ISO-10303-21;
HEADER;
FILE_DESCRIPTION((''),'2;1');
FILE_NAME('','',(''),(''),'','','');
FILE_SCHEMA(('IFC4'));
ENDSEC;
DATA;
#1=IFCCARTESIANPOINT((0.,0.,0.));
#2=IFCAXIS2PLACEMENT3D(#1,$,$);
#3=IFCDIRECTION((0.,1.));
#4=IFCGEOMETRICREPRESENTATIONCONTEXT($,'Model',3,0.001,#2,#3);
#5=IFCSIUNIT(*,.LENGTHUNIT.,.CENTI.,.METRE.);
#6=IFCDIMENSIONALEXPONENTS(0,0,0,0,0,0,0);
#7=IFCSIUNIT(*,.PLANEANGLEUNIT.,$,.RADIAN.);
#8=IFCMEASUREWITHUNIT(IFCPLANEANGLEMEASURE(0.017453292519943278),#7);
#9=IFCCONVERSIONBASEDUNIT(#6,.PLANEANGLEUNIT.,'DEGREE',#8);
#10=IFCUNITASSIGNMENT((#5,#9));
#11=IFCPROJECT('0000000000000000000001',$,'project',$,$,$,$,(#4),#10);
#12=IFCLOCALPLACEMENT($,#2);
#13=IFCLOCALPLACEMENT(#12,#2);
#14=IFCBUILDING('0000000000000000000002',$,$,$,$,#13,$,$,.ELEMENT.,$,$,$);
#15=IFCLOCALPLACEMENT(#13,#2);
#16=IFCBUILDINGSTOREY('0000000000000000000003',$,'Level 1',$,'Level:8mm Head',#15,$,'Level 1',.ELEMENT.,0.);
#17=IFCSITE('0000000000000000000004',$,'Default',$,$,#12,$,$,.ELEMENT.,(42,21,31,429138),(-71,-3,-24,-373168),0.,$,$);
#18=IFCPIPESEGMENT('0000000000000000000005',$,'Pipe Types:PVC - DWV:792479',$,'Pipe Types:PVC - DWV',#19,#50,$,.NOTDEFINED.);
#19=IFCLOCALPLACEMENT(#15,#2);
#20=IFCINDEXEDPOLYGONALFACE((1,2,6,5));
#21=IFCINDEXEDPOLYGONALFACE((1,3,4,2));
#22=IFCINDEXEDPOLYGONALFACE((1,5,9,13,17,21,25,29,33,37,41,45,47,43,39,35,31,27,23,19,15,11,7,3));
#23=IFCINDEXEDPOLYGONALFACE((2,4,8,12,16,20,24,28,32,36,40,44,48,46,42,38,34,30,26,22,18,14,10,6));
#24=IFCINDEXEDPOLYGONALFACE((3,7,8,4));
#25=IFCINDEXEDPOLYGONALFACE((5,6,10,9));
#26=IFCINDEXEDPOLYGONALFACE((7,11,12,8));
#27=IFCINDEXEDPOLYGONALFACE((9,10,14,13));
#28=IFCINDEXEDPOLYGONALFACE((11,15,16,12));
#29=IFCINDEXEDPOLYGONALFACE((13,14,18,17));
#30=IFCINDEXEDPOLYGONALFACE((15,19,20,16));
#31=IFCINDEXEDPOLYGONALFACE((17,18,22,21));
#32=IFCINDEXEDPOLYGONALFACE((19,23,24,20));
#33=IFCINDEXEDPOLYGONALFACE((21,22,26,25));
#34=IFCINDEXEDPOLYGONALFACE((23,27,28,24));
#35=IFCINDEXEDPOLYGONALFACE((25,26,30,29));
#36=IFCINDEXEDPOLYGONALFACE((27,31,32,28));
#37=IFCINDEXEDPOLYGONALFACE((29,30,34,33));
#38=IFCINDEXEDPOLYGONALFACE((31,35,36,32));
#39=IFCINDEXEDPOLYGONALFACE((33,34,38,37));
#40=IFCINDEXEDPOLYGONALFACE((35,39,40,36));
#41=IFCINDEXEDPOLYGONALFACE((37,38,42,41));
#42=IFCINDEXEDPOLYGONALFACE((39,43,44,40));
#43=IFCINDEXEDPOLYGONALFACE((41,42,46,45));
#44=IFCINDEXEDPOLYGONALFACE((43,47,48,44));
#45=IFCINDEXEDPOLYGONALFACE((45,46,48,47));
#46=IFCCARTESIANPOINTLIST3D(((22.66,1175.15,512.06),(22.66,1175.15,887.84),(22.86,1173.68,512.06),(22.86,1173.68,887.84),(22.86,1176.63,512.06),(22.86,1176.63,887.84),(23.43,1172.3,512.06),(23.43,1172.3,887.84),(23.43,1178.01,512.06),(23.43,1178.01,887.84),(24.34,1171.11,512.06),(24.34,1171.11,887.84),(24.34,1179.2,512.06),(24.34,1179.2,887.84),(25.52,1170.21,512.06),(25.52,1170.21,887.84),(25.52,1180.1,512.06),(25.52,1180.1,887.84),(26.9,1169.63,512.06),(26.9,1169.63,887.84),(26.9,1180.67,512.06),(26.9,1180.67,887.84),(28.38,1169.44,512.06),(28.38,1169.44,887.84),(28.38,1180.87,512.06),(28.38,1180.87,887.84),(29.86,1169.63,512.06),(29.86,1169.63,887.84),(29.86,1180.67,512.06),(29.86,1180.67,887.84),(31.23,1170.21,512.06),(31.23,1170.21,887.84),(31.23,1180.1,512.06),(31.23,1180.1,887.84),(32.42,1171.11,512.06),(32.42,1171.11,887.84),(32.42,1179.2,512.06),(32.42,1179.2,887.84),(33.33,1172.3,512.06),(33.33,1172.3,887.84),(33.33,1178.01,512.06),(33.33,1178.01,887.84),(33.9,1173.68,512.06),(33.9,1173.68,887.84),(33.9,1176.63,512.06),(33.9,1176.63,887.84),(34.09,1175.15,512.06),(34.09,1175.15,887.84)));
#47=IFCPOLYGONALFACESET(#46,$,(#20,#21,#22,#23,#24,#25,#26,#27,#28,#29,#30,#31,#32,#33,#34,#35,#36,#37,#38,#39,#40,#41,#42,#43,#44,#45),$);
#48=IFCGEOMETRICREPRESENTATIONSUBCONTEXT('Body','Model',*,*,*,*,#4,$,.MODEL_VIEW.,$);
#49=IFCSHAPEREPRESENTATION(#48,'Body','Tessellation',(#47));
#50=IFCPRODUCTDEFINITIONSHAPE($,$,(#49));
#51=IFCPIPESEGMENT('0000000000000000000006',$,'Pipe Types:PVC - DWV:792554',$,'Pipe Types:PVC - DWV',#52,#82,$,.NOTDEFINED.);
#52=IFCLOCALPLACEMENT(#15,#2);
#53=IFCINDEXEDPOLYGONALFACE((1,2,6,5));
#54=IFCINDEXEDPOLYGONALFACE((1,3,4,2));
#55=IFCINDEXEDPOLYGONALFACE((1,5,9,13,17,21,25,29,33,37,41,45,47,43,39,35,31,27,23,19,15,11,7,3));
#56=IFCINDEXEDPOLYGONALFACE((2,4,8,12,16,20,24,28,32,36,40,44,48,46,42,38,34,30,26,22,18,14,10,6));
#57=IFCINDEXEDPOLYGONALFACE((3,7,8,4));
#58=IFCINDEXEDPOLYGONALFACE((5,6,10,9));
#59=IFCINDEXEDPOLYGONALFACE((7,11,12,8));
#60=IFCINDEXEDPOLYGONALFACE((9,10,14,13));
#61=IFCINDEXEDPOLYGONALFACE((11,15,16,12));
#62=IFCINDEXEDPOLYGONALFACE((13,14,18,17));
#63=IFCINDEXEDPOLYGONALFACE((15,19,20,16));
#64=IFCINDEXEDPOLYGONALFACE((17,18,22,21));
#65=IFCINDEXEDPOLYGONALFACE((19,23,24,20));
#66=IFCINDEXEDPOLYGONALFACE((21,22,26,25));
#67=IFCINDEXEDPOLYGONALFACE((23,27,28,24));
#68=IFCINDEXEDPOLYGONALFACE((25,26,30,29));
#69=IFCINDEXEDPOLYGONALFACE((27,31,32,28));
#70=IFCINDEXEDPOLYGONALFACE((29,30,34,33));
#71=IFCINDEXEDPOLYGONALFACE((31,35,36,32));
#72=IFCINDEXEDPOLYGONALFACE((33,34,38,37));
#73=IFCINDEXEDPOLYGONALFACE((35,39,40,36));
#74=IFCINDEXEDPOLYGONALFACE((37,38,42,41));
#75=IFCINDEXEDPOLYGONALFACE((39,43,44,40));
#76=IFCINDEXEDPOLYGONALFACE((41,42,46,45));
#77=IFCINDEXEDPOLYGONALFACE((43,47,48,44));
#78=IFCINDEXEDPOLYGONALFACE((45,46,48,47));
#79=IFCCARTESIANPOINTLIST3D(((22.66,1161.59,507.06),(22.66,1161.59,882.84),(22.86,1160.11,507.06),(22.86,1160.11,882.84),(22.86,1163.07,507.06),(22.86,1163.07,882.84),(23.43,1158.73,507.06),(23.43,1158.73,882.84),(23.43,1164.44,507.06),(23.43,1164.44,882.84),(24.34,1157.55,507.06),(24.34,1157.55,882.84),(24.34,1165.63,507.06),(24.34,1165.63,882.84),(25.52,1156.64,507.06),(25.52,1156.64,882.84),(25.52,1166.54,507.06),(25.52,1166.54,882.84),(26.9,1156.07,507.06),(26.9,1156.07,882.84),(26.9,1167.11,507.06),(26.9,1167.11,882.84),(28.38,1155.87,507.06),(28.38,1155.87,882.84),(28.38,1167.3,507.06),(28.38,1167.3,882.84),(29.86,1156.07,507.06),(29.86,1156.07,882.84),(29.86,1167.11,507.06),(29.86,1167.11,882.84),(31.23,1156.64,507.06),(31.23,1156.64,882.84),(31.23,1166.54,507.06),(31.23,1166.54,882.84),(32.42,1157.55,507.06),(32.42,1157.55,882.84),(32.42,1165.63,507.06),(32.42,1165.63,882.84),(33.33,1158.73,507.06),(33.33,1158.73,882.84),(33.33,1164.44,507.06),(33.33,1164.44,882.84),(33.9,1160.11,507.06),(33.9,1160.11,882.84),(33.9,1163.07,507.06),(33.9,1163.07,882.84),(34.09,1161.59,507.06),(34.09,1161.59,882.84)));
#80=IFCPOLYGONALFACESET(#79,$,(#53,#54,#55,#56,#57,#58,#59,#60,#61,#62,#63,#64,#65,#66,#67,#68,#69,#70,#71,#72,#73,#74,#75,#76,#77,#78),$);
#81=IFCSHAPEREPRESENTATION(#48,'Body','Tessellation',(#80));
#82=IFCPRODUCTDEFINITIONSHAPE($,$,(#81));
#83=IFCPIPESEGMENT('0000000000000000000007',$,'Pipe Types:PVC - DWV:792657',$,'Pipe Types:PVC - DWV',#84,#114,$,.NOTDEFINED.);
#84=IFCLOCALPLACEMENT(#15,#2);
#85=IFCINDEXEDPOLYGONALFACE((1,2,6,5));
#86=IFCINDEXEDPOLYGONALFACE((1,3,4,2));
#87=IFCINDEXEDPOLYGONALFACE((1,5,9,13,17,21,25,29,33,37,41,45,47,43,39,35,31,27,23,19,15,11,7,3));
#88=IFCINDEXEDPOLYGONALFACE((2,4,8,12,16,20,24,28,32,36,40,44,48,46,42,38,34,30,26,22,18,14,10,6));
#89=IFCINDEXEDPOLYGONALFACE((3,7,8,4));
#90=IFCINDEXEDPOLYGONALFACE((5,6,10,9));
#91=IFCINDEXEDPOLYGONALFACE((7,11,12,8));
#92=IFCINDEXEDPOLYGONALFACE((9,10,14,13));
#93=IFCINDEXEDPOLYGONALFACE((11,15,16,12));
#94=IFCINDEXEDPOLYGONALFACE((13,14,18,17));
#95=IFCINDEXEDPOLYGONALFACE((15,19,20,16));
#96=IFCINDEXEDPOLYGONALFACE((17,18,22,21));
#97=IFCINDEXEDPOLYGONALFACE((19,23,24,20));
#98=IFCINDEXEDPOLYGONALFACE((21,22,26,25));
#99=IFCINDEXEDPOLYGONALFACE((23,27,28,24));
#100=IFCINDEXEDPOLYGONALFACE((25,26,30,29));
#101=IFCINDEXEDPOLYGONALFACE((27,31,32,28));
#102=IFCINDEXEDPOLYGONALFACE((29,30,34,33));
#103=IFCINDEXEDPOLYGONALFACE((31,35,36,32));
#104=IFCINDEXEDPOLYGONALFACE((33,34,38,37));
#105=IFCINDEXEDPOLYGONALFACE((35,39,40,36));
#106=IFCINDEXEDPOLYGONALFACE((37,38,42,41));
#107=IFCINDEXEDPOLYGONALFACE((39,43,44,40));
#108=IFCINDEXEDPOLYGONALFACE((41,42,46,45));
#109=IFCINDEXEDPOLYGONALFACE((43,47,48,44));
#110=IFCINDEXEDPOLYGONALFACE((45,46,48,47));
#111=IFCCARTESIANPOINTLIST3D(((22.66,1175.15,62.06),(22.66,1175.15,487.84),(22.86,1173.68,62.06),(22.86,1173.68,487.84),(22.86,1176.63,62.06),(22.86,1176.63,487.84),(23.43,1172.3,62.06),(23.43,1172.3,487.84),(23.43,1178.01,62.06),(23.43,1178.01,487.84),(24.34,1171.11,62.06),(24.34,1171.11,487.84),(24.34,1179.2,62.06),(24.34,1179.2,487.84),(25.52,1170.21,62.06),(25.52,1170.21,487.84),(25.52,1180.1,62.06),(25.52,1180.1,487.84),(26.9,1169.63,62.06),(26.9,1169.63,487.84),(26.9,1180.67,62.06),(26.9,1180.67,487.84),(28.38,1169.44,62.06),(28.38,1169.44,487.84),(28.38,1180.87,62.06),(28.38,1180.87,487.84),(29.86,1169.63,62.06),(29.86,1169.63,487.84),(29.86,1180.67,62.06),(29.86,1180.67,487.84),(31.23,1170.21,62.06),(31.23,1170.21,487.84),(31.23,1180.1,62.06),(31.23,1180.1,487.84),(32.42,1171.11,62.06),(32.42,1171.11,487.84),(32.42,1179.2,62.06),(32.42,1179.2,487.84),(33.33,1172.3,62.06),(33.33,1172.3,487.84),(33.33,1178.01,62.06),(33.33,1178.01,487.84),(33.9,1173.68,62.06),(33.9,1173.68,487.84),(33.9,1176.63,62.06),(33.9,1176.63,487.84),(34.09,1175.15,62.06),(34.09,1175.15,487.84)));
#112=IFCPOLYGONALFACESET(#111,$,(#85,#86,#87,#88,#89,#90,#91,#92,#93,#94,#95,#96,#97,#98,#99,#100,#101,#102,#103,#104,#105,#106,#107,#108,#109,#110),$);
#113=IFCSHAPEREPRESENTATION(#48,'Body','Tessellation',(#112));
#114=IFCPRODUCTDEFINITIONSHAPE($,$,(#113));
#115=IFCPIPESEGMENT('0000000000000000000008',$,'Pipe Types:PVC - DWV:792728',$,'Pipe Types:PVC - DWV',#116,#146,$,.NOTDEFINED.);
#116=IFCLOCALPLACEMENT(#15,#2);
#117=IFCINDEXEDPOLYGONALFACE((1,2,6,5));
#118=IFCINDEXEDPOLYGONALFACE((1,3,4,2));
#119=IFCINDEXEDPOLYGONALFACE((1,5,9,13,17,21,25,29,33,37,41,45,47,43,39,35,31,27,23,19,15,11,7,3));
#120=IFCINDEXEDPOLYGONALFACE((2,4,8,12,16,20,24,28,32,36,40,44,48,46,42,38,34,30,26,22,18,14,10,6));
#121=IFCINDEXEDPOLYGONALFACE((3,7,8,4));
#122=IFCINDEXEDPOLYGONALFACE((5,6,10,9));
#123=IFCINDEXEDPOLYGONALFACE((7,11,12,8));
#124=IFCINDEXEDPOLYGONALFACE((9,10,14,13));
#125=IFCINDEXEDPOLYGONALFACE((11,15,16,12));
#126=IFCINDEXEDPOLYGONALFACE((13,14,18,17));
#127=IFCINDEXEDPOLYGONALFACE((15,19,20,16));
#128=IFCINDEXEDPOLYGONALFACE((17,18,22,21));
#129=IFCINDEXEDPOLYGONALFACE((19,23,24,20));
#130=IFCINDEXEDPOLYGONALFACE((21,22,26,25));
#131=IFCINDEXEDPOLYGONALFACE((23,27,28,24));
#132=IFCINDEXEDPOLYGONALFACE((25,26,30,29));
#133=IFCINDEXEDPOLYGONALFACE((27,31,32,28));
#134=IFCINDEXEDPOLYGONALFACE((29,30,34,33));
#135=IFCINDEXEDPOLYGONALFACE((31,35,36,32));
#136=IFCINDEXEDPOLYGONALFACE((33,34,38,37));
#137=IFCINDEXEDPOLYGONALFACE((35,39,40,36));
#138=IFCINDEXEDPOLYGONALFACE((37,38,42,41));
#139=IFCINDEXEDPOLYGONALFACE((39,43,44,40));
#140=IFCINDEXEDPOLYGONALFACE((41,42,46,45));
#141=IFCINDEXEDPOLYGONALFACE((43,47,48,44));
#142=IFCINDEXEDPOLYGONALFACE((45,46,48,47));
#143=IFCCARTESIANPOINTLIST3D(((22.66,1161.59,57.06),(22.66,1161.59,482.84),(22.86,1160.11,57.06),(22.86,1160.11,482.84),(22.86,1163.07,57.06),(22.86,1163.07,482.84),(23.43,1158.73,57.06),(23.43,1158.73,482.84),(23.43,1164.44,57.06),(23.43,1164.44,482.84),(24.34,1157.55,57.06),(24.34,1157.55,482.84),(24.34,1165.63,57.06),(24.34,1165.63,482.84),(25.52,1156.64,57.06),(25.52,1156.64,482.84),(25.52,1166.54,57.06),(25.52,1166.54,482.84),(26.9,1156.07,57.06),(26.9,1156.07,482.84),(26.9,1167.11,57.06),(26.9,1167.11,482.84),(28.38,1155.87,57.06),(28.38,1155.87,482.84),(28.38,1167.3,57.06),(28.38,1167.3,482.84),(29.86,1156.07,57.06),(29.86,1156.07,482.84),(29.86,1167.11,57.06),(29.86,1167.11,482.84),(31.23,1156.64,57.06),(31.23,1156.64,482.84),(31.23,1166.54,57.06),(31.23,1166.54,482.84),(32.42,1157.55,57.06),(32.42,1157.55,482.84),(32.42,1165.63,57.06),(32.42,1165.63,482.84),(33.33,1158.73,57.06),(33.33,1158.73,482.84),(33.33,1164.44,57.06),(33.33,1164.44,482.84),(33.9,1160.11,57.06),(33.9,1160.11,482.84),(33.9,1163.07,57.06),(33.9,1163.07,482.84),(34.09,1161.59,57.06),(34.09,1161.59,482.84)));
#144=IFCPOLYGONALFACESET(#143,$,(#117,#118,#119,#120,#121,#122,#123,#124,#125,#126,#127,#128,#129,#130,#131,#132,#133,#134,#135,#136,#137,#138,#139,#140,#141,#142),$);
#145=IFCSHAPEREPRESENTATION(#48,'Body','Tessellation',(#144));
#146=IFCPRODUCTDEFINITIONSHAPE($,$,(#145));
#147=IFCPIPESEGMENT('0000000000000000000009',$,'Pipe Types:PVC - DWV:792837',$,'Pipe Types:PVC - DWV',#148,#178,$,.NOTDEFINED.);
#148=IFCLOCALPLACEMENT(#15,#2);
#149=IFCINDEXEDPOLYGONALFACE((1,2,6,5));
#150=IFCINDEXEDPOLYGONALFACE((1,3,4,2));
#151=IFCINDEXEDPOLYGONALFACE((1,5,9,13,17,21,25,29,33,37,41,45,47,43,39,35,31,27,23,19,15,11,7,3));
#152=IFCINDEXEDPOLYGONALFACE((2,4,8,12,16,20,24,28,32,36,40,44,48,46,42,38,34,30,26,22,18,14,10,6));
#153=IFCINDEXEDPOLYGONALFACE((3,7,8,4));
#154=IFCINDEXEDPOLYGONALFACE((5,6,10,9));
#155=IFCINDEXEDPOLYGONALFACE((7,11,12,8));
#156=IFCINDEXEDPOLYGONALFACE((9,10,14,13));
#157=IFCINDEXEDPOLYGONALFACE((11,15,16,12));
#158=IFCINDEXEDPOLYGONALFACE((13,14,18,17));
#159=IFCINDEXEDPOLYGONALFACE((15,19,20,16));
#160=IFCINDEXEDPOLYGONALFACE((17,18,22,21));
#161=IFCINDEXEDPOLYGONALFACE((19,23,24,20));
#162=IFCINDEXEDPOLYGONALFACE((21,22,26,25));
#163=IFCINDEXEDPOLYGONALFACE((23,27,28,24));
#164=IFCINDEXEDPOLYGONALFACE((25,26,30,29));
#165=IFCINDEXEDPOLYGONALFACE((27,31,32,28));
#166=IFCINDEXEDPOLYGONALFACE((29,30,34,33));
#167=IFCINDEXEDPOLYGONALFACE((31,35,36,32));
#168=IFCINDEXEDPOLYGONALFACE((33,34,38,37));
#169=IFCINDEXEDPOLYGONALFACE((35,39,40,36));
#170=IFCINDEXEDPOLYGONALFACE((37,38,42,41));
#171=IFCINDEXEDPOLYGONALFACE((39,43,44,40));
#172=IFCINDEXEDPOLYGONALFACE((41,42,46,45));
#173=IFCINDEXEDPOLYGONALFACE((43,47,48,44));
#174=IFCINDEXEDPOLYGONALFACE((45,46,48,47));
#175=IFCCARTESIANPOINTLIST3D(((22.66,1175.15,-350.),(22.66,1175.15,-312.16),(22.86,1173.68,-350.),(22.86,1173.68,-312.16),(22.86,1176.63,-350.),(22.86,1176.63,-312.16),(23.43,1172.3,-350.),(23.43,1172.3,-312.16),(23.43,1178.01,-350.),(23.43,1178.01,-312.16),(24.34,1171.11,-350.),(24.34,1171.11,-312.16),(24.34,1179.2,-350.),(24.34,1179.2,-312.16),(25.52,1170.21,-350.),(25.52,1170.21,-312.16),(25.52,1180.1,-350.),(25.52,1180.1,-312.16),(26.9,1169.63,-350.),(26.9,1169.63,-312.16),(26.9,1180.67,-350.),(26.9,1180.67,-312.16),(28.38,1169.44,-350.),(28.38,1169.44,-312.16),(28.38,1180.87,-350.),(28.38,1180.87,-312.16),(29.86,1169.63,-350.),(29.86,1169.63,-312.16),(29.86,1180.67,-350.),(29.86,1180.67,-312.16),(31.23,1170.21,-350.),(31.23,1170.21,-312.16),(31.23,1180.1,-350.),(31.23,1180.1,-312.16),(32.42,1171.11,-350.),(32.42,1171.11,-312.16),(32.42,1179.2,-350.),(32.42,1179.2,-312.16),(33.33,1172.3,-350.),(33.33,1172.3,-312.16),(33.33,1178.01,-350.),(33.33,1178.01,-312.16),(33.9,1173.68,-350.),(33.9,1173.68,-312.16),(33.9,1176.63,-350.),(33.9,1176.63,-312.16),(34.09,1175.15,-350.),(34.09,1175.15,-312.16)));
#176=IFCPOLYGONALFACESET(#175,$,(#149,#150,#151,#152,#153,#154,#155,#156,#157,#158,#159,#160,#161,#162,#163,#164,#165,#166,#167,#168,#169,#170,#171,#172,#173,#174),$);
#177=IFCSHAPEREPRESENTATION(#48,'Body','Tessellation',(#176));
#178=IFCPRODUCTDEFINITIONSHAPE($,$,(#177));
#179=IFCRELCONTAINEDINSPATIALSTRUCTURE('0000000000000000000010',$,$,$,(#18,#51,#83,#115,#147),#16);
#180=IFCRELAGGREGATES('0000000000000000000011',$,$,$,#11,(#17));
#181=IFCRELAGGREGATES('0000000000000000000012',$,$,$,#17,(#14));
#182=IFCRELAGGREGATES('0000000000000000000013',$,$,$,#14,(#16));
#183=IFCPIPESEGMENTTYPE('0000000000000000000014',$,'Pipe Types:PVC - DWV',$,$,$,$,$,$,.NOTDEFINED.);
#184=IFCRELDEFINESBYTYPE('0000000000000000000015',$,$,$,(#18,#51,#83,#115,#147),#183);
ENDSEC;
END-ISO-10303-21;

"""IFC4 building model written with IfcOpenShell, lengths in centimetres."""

from ifc_helpers import new_model, entity, si_unit, converted_unit, direction, frame, origin, place, context, subcontext, project, spatial, arc, indexed_curve, outline, extrude, type_object, element, save


model = new_model("IFC4")

# Units and contexts
model_context = context("Model", 3, precision=0.001, world=origin(), true_north=direction((0.0, 1.0)))
body_context = subcontext(model_context, "Body", "Model", "MODEL_VIEW")
ifc_project = project(units=[si_unit("LENGTHUNIT", "METRE", prefix="CENTI"), converted_unit("PLANEANGLEUNIT", "DEGREE", entity("IfcPlaneAngleMeasure", 0.017453292519943278), si_unit("PLANEANGLEUNIT", "RADIAN"), dimensions=[0, 0, 0, 0, 0, 0, 0])], contexts=[model_context])

# Site, building, storey
site_placement = place(None, origin())
site = spatial("IfcSite", under=ifc_project, at=site_placement, Name="Default", CompositionType="ELEMENT", RefLatitude=(42, 21, 31, 429138), RefLongitude=(-71, -3, -24, -373168), RefElevation=0.0)
building_placement = place(site_placement, origin())
building = spatial("IfcBuilding", under=site, at=building_placement, CompositionType="ELEMENT")
storey_placement = place(building_placement, origin())
storey = spatial("IfcBuildingStorey", under=building, at=storey_placement, Name="Level 1", ObjectType="Level:8mm Head", LongName="Level 1", CompositionType="ELEMENT", Elevation=0.0)

# Pipe segments
pipe_segment_type = type_object("IfcPipeSegmentType", Name="Pipe Types:PVC - DWV", PredefinedType="NOTDEFINED")
pipe_segment_1_placement = place(storey_placement, origin())
element("IfcPipeSegment", 1, at=pipe_segment_1_placement, inside=storey, type_object=pipe_segment_type, Name="Pipe Types:PVC - DWV:792479", ObjectType="Pipe Types:PVC - DWV", PredefinedType="NOTDEFINED", context=body_context, shape_type="SweptSolid", body=[
    extrude(outline(indexed_curve([(5.72, 0.0), (4.04, 4.04), (0.0, 5.71), (-4.04, 4.04), (-5.71, 0.0), (-4.04, -4.04), (0.0, -5.71), (4.04, -4.04)], segments=[arc(1, 2, 3), arc(3, 4, 5), arc(5, 6, 7), arc(7, 8, 1)], self_intersect=False)), frame((28.38, 1175.15, 512.06), z_axis=(0.0, 0.0, 1.0), x_axis=(-1.0, 0.0, 0.0)), (0.0, 0.0, 1.0), 375.78),
])
pipe_segment_2_placement = place(storey_placement, origin())
element("IfcPipeSegment", 2, at=pipe_segment_2_placement, inside=storey, type_object=pipe_segment_type, Name="Pipe Types:PVC - DWV:792554", ObjectType="Pipe Types:PVC - DWV", PredefinedType="NOTDEFINED", context=body_context, shape_type="SweptSolid", body=[
    extrude(outline(indexed_curve([(5.72, 0.0), (4.04, 4.04), (0.0, 5.71), (-4.04, 4.04), (-5.71, 0.0), (-4.04, -4.04), (0.0, -5.71), (4.04, -4.04)], segments=[arc(1, 2, 3), arc(3, 4, 5), arc(5, 6, 7), arc(7, 8, 1)], self_intersect=False)), frame((28.38, 1161.59, 507.06), z_axis=(0.0, 0.0, 1.0), x_axis=(-1.0, 0.0, 0.0)), (0.0, 0.0, 1.0), 375.78),
])
pipe_segment_3_placement = place(storey_placement, origin())
element("IfcPipeSegment", 3, at=pipe_segment_3_placement, inside=storey, type_object=pipe_segment_type, Name="Pipe Types:PVC - DWV:792657", ObjectType="Pipe Types:PVC - DWV", PredefinedType="NOTDEFINED", context=body_context, shape_type="SweptSolid", body=[
    extrude(outline(indexed_curve([(5.72, 0.0), (4.04, 4.04), (0.0, 5.71), (-4.04, 4.04), (-5.71, 0.0), (-4.04, -4.04), (0.0, -5.71), (4.04, -4.04)], segments=[arc(1, 2, 3), arc(3, 4, 5), arc(5, 6, 7), arc(7, 8, 1)], self_intersect=False)), frame((28.38, 1175.15, 62.06), z_axis=(0.0, 0.0, 1.0), x_axis=(-1.0, 0.0, 0.0)), (0.0, 0.0, 1.0), 425.78),
])
pipe_segment_4_placement = place(storey_placement, origin())
element("IfcPipeSegment", 4, at=pipe_segment_4_placement, inside=storey, type_object=pipe_segment_type, Name="Pipe Types:PVC - DWV:792728", ObjectType="Pipe Types:PVC - DWV", PredefinedType="NOTDEFINED", context=body_context, shape_type="SweptSolid", body=[
    extrude(outline(indexed_curve([(5.72, 0.0), (4.04, 4.04), (0.0, 5.71), (-4.04, 4.04), (-5.71, 0.0), (-4.04, -4.04), (0.0, -5.71), (4.04, -4.04)], segments=[arc(1, 2, 3), arc(3, 4, 5), arc(5, 6, 7), arc(7, 8, 1)], self_intersect=False)), frame((28.38, 1161.59, 57.06), z_axis=(0.0, 0.0, 1.0), x_axis=(-1.0, 0.0, 0.0)), (0.0, 0.0, 1.0), 425.78),
])
pipe_segment_5_placement = place(storey_placement, origin())
element("IfcPipeSegment", 5, at=pipe_segment_5_placement, inside=storey, type_object=pipe_segment_type, Name="Pipe Types:PVC - DWV:792837", ObjectType="Pipe Types:PVC - DWV", PredefinedType="NOTDEFINED", context=body_context, shape_type="SweptSolid", body=[
    extrude(outline(indexed_curve([(5.72, 0.0), (4.04, 4.04), (0.0, 5.71), (-4.04, 4.04), (-5.71, 0.0), (-4.04, -4.04), (0.0, -5.71), (4.04, -4.04)], segments=[arc(1, 2, 3), arc(3, 4, 5), arc(5, 6, 7), arc(7, 8, 1)], self_intersect=False)), frame((28.38, 1175.15, -350.0), z_axis=(0.0, 0.0, 1.0), x_axis=(-1.0, 0.0, 0.0)), (0.0, 0.0, 1.0), 37.84),
])

save(model, "model.ifc")
